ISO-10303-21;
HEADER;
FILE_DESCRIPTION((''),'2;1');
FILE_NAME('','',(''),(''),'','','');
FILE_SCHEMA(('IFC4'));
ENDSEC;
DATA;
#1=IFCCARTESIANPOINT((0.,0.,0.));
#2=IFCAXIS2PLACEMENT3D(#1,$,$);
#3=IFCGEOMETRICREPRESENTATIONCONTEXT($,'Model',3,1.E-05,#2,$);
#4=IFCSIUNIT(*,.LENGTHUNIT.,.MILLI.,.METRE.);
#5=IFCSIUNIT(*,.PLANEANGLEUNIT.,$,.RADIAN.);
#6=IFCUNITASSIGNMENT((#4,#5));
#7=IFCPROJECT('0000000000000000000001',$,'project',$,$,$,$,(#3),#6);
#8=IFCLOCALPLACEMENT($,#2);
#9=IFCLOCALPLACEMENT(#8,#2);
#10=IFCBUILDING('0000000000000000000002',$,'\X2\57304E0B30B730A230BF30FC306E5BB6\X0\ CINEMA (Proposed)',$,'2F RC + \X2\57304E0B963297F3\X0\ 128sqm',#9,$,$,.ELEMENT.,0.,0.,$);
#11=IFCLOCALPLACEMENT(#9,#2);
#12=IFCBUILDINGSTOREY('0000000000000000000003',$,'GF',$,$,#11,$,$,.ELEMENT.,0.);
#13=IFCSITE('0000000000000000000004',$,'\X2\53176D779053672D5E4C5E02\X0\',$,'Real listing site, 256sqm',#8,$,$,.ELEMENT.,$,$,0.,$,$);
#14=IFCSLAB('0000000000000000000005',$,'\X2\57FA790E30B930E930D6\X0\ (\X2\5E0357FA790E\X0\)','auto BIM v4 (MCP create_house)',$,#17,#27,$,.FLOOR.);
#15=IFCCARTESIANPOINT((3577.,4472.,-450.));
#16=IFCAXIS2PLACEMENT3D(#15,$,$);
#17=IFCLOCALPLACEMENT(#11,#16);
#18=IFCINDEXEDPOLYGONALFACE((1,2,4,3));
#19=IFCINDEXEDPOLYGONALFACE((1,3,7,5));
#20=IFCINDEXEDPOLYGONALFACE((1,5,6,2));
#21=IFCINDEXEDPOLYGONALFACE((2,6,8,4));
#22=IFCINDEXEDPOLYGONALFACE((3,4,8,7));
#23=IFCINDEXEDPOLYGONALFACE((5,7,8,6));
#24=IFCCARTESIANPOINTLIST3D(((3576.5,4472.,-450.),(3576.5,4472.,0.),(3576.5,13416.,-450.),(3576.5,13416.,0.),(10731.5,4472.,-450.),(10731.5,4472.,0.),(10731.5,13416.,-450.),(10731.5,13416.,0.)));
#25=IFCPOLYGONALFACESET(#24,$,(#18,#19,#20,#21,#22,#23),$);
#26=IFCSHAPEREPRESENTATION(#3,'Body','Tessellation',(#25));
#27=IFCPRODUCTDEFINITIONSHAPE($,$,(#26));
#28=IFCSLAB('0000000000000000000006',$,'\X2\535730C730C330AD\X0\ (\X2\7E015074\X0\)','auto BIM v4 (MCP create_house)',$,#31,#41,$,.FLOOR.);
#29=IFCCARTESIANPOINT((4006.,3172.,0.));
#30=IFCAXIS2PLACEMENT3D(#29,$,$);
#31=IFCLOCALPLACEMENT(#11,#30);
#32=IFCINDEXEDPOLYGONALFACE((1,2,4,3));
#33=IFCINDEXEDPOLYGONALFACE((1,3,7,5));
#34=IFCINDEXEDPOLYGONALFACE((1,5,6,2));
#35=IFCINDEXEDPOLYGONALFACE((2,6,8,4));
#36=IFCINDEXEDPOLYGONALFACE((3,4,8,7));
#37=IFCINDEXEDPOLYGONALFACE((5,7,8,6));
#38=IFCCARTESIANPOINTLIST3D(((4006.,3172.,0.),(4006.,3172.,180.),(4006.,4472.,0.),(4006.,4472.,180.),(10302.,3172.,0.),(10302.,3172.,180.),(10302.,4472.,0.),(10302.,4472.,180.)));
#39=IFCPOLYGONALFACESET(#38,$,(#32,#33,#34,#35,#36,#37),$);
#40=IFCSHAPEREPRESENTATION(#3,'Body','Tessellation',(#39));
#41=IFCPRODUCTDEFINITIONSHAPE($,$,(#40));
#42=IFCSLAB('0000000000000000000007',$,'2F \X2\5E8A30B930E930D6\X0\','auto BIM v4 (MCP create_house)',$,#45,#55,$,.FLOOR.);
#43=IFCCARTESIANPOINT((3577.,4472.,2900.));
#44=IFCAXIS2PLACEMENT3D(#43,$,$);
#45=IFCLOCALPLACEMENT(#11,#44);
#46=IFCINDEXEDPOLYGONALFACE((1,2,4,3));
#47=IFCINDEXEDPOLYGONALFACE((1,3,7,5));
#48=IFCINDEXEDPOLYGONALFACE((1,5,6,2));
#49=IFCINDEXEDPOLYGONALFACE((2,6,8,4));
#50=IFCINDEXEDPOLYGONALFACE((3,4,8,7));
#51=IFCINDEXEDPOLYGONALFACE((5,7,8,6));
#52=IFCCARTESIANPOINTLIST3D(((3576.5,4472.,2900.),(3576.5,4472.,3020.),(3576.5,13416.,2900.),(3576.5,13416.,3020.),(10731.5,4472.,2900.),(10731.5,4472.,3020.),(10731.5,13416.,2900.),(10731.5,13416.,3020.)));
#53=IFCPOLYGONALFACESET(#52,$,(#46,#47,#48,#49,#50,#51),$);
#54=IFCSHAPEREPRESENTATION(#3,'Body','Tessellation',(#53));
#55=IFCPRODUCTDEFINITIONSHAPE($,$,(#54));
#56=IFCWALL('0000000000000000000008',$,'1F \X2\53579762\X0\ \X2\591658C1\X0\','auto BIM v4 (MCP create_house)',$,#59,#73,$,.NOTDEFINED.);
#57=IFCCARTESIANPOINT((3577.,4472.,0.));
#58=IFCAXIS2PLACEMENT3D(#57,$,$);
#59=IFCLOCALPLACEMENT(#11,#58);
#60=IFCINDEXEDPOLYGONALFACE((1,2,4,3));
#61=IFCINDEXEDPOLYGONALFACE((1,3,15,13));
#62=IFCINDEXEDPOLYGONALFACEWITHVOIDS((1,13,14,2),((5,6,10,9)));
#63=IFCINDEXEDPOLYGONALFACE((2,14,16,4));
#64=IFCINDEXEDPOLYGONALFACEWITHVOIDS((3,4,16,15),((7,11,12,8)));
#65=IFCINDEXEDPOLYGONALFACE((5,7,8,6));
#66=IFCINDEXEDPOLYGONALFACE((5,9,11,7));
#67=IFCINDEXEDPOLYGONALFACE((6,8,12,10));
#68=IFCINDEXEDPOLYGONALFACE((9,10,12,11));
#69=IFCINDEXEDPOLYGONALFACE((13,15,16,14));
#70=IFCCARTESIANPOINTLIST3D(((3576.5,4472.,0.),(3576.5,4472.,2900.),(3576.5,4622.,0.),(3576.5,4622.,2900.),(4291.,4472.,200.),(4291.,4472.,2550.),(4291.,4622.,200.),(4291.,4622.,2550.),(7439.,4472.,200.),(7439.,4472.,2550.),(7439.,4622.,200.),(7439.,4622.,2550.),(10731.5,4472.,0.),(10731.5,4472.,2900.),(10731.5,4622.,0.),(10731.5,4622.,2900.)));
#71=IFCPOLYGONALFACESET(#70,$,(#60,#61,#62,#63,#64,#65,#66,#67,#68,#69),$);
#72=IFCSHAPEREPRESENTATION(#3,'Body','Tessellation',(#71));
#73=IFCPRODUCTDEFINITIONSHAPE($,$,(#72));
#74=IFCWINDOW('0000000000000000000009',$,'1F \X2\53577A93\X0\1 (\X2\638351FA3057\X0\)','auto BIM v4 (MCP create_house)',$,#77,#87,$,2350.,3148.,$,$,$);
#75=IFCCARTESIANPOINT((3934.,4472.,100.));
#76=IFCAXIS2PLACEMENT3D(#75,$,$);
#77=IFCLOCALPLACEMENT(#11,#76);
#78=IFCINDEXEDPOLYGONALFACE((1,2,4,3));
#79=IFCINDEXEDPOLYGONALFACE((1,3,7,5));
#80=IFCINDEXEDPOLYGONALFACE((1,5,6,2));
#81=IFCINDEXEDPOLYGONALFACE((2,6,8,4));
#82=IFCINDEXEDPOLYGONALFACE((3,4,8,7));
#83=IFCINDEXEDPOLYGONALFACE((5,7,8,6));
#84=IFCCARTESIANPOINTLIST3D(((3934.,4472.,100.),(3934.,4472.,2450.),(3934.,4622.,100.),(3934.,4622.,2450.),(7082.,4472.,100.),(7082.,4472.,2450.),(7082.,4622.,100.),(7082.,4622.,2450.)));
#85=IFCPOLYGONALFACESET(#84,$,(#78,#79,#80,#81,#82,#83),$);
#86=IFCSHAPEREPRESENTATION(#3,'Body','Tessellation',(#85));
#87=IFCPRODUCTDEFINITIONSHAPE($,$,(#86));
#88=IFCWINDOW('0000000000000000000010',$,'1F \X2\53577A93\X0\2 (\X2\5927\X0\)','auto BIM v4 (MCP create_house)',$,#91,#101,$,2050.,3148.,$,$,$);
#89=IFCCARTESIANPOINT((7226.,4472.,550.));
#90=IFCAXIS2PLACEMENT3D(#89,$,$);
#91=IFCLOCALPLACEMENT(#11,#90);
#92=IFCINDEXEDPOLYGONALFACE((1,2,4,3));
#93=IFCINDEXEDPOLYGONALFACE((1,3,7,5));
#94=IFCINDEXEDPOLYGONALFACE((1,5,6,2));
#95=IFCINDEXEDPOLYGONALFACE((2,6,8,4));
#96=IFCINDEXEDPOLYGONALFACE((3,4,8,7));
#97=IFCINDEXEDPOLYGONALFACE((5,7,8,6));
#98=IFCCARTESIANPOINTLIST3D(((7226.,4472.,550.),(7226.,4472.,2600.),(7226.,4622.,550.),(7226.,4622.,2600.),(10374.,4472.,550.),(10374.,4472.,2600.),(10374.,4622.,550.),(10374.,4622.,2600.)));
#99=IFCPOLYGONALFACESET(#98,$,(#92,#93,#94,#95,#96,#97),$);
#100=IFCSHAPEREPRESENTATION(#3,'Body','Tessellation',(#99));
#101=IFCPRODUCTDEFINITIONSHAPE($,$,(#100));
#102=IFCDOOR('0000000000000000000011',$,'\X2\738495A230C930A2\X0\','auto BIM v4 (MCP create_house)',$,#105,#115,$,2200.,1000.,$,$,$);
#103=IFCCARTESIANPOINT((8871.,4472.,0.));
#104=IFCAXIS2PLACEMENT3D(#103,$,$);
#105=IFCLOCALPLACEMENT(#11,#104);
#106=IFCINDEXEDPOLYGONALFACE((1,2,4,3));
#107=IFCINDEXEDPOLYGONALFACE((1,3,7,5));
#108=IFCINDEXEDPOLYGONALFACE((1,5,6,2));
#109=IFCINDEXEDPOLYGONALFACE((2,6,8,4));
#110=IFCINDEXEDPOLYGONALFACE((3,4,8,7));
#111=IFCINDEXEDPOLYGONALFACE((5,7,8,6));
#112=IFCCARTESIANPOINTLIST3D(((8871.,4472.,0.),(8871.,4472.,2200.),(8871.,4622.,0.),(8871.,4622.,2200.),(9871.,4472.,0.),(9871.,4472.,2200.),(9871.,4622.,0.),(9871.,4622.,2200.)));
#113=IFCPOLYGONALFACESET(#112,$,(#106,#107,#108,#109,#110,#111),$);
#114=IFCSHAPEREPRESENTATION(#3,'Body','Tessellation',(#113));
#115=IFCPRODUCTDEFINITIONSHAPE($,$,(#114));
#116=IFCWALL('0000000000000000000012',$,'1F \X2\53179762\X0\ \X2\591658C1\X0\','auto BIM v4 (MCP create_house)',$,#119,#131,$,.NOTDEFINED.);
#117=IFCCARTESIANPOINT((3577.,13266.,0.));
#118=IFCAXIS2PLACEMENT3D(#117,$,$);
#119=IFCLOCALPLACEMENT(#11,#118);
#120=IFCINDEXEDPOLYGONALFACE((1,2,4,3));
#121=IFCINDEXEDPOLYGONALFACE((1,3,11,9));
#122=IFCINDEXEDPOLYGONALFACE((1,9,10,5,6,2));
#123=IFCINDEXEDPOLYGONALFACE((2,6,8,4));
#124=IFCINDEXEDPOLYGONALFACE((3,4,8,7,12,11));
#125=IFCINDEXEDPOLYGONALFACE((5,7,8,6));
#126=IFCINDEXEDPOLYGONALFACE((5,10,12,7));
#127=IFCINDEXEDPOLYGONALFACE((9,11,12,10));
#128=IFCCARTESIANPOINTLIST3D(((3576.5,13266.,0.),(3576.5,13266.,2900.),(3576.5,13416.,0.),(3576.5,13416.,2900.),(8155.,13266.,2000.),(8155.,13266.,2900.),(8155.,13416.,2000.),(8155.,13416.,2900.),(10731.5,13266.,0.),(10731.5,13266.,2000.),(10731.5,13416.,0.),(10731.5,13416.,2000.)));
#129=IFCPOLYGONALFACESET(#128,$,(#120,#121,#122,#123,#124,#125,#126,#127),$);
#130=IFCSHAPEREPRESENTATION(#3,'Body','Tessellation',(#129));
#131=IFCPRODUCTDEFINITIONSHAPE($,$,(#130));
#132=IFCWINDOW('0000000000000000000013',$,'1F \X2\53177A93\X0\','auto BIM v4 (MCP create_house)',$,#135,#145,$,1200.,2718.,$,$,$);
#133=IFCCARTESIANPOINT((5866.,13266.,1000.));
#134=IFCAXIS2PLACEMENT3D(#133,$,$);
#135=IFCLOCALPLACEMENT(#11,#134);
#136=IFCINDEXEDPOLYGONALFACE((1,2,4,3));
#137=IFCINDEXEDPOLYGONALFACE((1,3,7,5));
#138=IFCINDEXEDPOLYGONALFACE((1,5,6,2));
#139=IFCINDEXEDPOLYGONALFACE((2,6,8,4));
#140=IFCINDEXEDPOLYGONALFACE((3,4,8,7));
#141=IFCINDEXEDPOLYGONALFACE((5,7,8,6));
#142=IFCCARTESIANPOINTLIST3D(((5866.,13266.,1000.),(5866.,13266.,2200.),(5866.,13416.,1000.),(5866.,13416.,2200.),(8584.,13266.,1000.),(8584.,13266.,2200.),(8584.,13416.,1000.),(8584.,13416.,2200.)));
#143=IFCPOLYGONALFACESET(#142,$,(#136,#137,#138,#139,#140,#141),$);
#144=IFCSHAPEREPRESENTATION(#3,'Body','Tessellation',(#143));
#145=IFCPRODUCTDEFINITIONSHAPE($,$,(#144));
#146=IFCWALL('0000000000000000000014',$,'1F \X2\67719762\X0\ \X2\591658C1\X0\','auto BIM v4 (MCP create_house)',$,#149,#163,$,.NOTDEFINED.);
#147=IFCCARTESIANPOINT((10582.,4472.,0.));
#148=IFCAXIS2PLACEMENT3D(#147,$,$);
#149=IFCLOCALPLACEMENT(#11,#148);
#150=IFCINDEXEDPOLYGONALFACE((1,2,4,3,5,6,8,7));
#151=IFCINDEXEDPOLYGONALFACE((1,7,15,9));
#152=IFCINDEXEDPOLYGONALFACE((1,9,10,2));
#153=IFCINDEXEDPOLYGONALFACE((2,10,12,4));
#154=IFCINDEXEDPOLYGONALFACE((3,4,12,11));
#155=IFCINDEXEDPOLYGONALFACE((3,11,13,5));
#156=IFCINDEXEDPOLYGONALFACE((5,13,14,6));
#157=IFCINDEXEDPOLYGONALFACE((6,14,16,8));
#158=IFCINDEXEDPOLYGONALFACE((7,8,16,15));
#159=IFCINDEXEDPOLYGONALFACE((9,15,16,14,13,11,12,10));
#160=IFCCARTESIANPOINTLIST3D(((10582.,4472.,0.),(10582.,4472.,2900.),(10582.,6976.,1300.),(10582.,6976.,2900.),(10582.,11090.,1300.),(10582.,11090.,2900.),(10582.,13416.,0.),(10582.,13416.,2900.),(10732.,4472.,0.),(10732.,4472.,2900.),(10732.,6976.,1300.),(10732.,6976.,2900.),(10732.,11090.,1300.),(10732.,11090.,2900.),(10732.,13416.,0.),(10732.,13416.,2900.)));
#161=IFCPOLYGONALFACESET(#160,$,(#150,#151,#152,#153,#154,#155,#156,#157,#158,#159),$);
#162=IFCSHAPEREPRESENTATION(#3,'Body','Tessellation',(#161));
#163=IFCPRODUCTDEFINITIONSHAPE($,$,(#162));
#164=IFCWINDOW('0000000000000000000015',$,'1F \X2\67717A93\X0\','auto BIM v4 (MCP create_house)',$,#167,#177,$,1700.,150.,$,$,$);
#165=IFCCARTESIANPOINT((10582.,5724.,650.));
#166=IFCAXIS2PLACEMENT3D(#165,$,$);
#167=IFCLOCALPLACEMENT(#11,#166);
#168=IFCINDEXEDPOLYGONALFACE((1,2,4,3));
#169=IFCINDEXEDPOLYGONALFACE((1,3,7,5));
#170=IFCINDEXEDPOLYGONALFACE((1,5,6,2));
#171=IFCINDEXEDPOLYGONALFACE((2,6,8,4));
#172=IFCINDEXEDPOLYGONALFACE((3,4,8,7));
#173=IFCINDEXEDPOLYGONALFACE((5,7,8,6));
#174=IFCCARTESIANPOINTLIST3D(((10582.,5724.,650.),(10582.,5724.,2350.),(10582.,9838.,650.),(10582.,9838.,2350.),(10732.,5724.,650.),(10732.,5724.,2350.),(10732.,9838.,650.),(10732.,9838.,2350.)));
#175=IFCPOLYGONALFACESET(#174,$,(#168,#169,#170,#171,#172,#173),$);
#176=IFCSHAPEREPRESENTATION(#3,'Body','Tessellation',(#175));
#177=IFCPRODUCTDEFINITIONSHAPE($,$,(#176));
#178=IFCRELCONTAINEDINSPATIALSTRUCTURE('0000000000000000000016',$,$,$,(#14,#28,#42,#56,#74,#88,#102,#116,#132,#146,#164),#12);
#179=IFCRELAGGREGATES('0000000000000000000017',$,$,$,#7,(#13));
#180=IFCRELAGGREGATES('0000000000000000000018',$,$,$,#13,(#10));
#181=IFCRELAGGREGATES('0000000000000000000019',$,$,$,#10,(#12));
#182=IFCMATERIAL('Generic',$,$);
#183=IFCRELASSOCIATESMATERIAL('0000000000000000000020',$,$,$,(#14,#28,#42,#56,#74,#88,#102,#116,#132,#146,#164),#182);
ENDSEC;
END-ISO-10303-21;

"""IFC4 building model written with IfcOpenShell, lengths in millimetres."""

from ifc_helpers import new_model, si_unit, frame, frame_2d, origin, place, context, project, spatial, rectangle, extrude, material, element, fill, save


model = new_model("IFC4")

# Units and contexts
model_context = context("Model", 3, precision=1e-05, world=origin())
ifc_project = project(units=[si_unit("LENGTHUNIT", "METRE", prefix="MILLI"), si_unit("PLANEANGLEUNIT", "RADIAN")], contexts=[model_context])

# Site, building, storey
site_placement = place(None, origin())
site = spatial("IfcSite", under=ifc_project, at=site_placement, Name="北海道札幌市", ObjectType="Real listing site, 256sqm", CompositionType="ELEMENT", RefElevation=0.0)
building_placement = place(site_placement, origin())
building = spatial("IfcBuilding", under=site, at=building_placement, Name="地下シアターの家 CINEMA (Proposed)", ObjectType="2F RC + 地下防音 128sqm", CompositionType="ELEMENT", ElevationOfRefHeight=0.0, ElevationOfTerrain=0.0)
storey_placement = place(building_placement, origin())
storey = spatial("IfcBuildingStorey", under=building, at=storey_placement, Name="GF", CompositionType="ELEMENT", Elevation=0.0)

# Slabs
ifc_material = material(Name="Generic")
slab_1_placement = place(storey_placement, frame((3577.0, 4472.0, -450.0)))
element("IfcSlab", 1, at=slab_1_placement, inside=storey, material=ifc_material, Name="基礎スラブ (布基礎)", Description="auto BIM v4 (MCP create_house)", PredefinedType="FLOOR", context=model_context, shape_type="SweptSolid", body=[
    extrude(rectangle(XDim=7155.0, YDim=8944.0, at=frame_2d((3577.0, 4472.0))), frame((3577.0, 4472.0, -450.0)), (0.0, 0.0, 1.0), 450.0),
])
slab_2_placement = place(storey_placement, frame((4006.0, 3172.0, 0.0)))
element("IfcSlab", 2, at=slab_2_placement, inside=storey, material=ifc_material, Name="南デッキ (縁側)", Description="auto BIM v4 (MCP create_house)", PredefinedType="FLOOR", context=model_context, shape_type="SweptSolid", body=[
    extrude(rectangle(XDim=6296.0, YDim=1300.0, at=frame_2d((3148.0, 650.0))), frame((4006.0, 3172.0, 0.0)), (0.0, 0.0, 1.0), 180.0),
])
slab_3_placement = place(storey_placement, frame((3577.0, 4472.0, 2900.0)))
element("IfcSlab", 3, at=slab_3_placement, inside=storey, material=ifc_material, Name="2F 床スラブ", Description="auto BIM v4 (MCP create_house)", PredefinedType="FLOOR", context=model_context, shape_type="SweptSolid", body=[
    extrude(rectangle(XDim=7155.0, YDim=8944.0, at=frame_2d((3577.0, 4472.0))), frame((3577.0, 4472.0, 2900.0)), (0.0, 0.0, 1.0), 120.0),
])

# Wall, openings, windows, door
wall_1_placement = place(storey_placement, frame((3577.0, 4472.0, 0.0)))
wall_1 = element("IfcWall", 4, at=wall_1_placement, inside=storey, material=ifc_material, Name="1F 南面 外壁", Description="auto BIM v4 (MCP create_house)", PredefinedType="NOTDEFINED", context=model_context, shape_type="SweptSolid", body=[
    extrude(rectangle(XDim=7155.0, YDim=150.0, at=frame_2d((3577.0, 75.0))), frame((3577.0, 4472.0, 0.0)), (0.0, 0.0, 1.0), 2900.0),
])
opening_1_placement = place(storey_placement, frame((3934.0, 4472.0, 100.0)))
opening_1 = element("IfcOpeningElement", 5, at=opening_1_placement, cuts=wall_1, PredefinedType="NOTDEFINED", context=model_context, shape_type="SweptSolid", body=[
    extrude(rectangle(XDim=3148.0, YDim=150.0, at=frame_2d((1574.0, 75.0))), frame((3934.0, 4472.0, 100.0)), (0.0, 0.0, 1.0), 2350.0),
])
opening_2_placement = place(storey_placement, frame((7226.0, 4472.0, 550.0)))
opening_2 = element("IfcOpeningElement", 6, at=opening_2_placement, cuts=wall_1, PredefinedType="NOTDEFINED", context=model_context, shape_type="SweptSolid", body=[
    extrude(rectangle(XDim=3148.0, YDim=150.0, at=frame_2d((1574.0, 75.0))), frame((7226.0, 4472.0, 550.0)), (0.0, 0.0, 1.0), 2050.0),
])
opening_3_placement = place(storey_placement, frame((8871.0, 4472.0, 0.0)))
opening_3 = element("IfcOpeningElement", 7, at=opening_3_placement, cuts=wall_1, PredefinedType="NOTDEFINED", context=model_context, shape_type="SweptSolid", body=[
    extrude(rectangle(XDim=1000.0, YDim=150.0, at=frame_2d((500.0, 75.0))), frame((8871.0, 4472.0, 0.0)), (0.0, 0.0, 1.0), 2200.0),
])
window_1_placement = place(storey_placement, frame((3934.0, 4472.0, 100.0)))
window_1 = element("IfcWindow", 8, at=window_1_placement, inside=storey, material=ifc_material, Name="1F 南窓1 (掃出し)", Description="auto BIM v4 (MCP create_house)", OverallHeight=2350.0, OverallWidth=3148.0, context=model_context, shape_type="SweptSolid", body=[
    extrude(rectangle(XDim=3148.0, YDim=150.0, at=frame_2d((1574.0, 75.0))), frame((3934.0, 4472.0, 100.0)), (0.0, 0.0, 1.0), 2350.0),
])
fill(opening_1, window_1)
window_2_placement = place(storey_placement, frame((7226.0, 4472.0, 550.0)))
window_2 = element("IfcWindow", 9, at=window_2_placement, inside=storey, material=ifc_material, Name="1F 南窓2 (大)", Description="auto BIM v4 (MCP create_house)", OverallHeight=2050.0, OverallWidth=3148.0, context=model_context, shape_type="SweptSolid", body=[
    extrude(rectangle(XDim=3148.0, YDim=150.0, at=frame_2d((1574.0, 75.0))), frame((7226.0, 4472.0, 550.0)), (0.0, 0.0, 1.0), 2050.0),
])
fill(opening_2, window_2)
door_1_placement = place(storey_placement, frame((8871.0, 4472.0, 0.0)))
door_1 = element("IfcDoor", 10, at=door_1_placement, inside=storey, material=ifc_material, Name="玄関ドア", Description="auto BIM v4 (MCP create_house)", OverallHeight=2200.0, OverallWidth=1000.0, context=model_context, shape_type="SweptSolid", body=[
    extrude(rectangle(XDim=1000.0, YDim=150.0, at=frame_2d((500.0, 75.0))), frame((8871.0, 4472.0, 0.0)), (0.0, 0.0, 1.0), 2200.0),
])
fill(opening_3, door_1)

# Walls, openings, windows
wall_2_placement = place(storey_placement, frame((3577.0, 13266.0, 0.0)))
wall_2 = element("IfcWall", 11, at=wall_2_placement, inside=storey, material=ifc_material, Name="1F 北面 外壁", Description="auto BIM v4 (MCP create_house)", PredefinedType="NOTDEFINED", context=model_context, shape_type="SweptSolid", body=[
    extrude(rectangle(XDim=7155.0, YDim=150.0, at=frame_2d((3577.0, 75.0))), frame((3577.0, 13266.0, 0.0)), (0.0, 0.0, 1.0), 2900.0),
])
opening_4_placement = place(storey_placement, frame((5866.0, 13266.0, 1000.0)))
opening_4 = element("IfcOpeningElement", 12, at=opening_4_placement, cuts=wall_2, PredefinedType="NOTDEFINED", context=model_context, shape_type="SweptSolid", body=[
    extrude(rectangle(XDim=2718.0, YDim=150.0, at=frame_2d((1359.0, 75.0))), frame((5866.0, 13266.0, 1000.0)), (0.0, 0.0, 1.0), 1200.0),
])
window_3_placement = place(storey_placement, frame((5866.0, 13266.0, 1000.0)))
window_3 = element("IfcWindow", 13, at=window_3_placement, inside=storey, material=ifc_material, Name="1F 北窓", Description="auto BIM v4 (MCP create_house)", OverallHeight=1200.0, OverallWidth=2718.0, context=model_context, shape_type="SweptSolid", body=[
    extrude(rectangle(XDim=2718.0, YDim=150.0, at=frame_2d((1359.0, 75.0))), frame((5866.0, 13266.0, 1000.0)), (0.0, 0.0, 1.0), 1200.0),
])
fill(opening_4, window_3)
wall_3_placement = place(storey_placement, frame((10582.0, 4472.0, 0.0)))
wall_3 = element("IfcWall", 14, at=wall_3_placement, inside=storey, material=ifc_material, Name="1F 東面 外壁", Description="auto BIM v4 (MCP create_house)", PredefinedType="NOTDEFINED", context=model_context, shape_type="SweptSolid", body=[
    extrude(rectangle(XDim=150.0, YDim=8944.0, at=frame_2d((75.0, 4472.0))), frame((10582.0, 4472.0, 0.0)), (0.0, 0.0, 1.0), 2900.0),
])
opening_5_placement = place(storey_placement, frame((10582.0, 5724.0, 650.0)))
opening_5 = element("IfcOpeningElement", 15, at=opening_5_placement, cuts=wall_3, PredefinedType="NOTDEFINED", context=model_context, shape_type="SweptSolid", body=[
    extrude(rectangle(XDim=150.0, YDim=4114.0, at=frame_2d((75.0, 2057.0))), frame((10582.0, 5724.0, 650.0)), (0.0, 0.0, 1.0), 1700.0),
])
window_4_placement = place(storey_placement, frame((10582.0, 5724.0, 650.0)))
window_4 = element("IfcWindow", 16, at=window_4_placement, inside=storey, material=ifc_material, Name="1F 東窓", Description="auto BIM v4 (MCP create_house)", OverallHeight=1700.0, OverallWidth=150.0, context=model_context, shape_type="SweptSolid", body=[
    extrude(rectangle(XDim=150.0, YDim=4114.0, at=frame_2d((75.0, 2057.0))), frame((10582.0, 5724.0, 650.0)), (0.0, 0.0, 1.0), 1700.0),
])
fill(opening_5, window_4)

save(model, "model.ifc")
